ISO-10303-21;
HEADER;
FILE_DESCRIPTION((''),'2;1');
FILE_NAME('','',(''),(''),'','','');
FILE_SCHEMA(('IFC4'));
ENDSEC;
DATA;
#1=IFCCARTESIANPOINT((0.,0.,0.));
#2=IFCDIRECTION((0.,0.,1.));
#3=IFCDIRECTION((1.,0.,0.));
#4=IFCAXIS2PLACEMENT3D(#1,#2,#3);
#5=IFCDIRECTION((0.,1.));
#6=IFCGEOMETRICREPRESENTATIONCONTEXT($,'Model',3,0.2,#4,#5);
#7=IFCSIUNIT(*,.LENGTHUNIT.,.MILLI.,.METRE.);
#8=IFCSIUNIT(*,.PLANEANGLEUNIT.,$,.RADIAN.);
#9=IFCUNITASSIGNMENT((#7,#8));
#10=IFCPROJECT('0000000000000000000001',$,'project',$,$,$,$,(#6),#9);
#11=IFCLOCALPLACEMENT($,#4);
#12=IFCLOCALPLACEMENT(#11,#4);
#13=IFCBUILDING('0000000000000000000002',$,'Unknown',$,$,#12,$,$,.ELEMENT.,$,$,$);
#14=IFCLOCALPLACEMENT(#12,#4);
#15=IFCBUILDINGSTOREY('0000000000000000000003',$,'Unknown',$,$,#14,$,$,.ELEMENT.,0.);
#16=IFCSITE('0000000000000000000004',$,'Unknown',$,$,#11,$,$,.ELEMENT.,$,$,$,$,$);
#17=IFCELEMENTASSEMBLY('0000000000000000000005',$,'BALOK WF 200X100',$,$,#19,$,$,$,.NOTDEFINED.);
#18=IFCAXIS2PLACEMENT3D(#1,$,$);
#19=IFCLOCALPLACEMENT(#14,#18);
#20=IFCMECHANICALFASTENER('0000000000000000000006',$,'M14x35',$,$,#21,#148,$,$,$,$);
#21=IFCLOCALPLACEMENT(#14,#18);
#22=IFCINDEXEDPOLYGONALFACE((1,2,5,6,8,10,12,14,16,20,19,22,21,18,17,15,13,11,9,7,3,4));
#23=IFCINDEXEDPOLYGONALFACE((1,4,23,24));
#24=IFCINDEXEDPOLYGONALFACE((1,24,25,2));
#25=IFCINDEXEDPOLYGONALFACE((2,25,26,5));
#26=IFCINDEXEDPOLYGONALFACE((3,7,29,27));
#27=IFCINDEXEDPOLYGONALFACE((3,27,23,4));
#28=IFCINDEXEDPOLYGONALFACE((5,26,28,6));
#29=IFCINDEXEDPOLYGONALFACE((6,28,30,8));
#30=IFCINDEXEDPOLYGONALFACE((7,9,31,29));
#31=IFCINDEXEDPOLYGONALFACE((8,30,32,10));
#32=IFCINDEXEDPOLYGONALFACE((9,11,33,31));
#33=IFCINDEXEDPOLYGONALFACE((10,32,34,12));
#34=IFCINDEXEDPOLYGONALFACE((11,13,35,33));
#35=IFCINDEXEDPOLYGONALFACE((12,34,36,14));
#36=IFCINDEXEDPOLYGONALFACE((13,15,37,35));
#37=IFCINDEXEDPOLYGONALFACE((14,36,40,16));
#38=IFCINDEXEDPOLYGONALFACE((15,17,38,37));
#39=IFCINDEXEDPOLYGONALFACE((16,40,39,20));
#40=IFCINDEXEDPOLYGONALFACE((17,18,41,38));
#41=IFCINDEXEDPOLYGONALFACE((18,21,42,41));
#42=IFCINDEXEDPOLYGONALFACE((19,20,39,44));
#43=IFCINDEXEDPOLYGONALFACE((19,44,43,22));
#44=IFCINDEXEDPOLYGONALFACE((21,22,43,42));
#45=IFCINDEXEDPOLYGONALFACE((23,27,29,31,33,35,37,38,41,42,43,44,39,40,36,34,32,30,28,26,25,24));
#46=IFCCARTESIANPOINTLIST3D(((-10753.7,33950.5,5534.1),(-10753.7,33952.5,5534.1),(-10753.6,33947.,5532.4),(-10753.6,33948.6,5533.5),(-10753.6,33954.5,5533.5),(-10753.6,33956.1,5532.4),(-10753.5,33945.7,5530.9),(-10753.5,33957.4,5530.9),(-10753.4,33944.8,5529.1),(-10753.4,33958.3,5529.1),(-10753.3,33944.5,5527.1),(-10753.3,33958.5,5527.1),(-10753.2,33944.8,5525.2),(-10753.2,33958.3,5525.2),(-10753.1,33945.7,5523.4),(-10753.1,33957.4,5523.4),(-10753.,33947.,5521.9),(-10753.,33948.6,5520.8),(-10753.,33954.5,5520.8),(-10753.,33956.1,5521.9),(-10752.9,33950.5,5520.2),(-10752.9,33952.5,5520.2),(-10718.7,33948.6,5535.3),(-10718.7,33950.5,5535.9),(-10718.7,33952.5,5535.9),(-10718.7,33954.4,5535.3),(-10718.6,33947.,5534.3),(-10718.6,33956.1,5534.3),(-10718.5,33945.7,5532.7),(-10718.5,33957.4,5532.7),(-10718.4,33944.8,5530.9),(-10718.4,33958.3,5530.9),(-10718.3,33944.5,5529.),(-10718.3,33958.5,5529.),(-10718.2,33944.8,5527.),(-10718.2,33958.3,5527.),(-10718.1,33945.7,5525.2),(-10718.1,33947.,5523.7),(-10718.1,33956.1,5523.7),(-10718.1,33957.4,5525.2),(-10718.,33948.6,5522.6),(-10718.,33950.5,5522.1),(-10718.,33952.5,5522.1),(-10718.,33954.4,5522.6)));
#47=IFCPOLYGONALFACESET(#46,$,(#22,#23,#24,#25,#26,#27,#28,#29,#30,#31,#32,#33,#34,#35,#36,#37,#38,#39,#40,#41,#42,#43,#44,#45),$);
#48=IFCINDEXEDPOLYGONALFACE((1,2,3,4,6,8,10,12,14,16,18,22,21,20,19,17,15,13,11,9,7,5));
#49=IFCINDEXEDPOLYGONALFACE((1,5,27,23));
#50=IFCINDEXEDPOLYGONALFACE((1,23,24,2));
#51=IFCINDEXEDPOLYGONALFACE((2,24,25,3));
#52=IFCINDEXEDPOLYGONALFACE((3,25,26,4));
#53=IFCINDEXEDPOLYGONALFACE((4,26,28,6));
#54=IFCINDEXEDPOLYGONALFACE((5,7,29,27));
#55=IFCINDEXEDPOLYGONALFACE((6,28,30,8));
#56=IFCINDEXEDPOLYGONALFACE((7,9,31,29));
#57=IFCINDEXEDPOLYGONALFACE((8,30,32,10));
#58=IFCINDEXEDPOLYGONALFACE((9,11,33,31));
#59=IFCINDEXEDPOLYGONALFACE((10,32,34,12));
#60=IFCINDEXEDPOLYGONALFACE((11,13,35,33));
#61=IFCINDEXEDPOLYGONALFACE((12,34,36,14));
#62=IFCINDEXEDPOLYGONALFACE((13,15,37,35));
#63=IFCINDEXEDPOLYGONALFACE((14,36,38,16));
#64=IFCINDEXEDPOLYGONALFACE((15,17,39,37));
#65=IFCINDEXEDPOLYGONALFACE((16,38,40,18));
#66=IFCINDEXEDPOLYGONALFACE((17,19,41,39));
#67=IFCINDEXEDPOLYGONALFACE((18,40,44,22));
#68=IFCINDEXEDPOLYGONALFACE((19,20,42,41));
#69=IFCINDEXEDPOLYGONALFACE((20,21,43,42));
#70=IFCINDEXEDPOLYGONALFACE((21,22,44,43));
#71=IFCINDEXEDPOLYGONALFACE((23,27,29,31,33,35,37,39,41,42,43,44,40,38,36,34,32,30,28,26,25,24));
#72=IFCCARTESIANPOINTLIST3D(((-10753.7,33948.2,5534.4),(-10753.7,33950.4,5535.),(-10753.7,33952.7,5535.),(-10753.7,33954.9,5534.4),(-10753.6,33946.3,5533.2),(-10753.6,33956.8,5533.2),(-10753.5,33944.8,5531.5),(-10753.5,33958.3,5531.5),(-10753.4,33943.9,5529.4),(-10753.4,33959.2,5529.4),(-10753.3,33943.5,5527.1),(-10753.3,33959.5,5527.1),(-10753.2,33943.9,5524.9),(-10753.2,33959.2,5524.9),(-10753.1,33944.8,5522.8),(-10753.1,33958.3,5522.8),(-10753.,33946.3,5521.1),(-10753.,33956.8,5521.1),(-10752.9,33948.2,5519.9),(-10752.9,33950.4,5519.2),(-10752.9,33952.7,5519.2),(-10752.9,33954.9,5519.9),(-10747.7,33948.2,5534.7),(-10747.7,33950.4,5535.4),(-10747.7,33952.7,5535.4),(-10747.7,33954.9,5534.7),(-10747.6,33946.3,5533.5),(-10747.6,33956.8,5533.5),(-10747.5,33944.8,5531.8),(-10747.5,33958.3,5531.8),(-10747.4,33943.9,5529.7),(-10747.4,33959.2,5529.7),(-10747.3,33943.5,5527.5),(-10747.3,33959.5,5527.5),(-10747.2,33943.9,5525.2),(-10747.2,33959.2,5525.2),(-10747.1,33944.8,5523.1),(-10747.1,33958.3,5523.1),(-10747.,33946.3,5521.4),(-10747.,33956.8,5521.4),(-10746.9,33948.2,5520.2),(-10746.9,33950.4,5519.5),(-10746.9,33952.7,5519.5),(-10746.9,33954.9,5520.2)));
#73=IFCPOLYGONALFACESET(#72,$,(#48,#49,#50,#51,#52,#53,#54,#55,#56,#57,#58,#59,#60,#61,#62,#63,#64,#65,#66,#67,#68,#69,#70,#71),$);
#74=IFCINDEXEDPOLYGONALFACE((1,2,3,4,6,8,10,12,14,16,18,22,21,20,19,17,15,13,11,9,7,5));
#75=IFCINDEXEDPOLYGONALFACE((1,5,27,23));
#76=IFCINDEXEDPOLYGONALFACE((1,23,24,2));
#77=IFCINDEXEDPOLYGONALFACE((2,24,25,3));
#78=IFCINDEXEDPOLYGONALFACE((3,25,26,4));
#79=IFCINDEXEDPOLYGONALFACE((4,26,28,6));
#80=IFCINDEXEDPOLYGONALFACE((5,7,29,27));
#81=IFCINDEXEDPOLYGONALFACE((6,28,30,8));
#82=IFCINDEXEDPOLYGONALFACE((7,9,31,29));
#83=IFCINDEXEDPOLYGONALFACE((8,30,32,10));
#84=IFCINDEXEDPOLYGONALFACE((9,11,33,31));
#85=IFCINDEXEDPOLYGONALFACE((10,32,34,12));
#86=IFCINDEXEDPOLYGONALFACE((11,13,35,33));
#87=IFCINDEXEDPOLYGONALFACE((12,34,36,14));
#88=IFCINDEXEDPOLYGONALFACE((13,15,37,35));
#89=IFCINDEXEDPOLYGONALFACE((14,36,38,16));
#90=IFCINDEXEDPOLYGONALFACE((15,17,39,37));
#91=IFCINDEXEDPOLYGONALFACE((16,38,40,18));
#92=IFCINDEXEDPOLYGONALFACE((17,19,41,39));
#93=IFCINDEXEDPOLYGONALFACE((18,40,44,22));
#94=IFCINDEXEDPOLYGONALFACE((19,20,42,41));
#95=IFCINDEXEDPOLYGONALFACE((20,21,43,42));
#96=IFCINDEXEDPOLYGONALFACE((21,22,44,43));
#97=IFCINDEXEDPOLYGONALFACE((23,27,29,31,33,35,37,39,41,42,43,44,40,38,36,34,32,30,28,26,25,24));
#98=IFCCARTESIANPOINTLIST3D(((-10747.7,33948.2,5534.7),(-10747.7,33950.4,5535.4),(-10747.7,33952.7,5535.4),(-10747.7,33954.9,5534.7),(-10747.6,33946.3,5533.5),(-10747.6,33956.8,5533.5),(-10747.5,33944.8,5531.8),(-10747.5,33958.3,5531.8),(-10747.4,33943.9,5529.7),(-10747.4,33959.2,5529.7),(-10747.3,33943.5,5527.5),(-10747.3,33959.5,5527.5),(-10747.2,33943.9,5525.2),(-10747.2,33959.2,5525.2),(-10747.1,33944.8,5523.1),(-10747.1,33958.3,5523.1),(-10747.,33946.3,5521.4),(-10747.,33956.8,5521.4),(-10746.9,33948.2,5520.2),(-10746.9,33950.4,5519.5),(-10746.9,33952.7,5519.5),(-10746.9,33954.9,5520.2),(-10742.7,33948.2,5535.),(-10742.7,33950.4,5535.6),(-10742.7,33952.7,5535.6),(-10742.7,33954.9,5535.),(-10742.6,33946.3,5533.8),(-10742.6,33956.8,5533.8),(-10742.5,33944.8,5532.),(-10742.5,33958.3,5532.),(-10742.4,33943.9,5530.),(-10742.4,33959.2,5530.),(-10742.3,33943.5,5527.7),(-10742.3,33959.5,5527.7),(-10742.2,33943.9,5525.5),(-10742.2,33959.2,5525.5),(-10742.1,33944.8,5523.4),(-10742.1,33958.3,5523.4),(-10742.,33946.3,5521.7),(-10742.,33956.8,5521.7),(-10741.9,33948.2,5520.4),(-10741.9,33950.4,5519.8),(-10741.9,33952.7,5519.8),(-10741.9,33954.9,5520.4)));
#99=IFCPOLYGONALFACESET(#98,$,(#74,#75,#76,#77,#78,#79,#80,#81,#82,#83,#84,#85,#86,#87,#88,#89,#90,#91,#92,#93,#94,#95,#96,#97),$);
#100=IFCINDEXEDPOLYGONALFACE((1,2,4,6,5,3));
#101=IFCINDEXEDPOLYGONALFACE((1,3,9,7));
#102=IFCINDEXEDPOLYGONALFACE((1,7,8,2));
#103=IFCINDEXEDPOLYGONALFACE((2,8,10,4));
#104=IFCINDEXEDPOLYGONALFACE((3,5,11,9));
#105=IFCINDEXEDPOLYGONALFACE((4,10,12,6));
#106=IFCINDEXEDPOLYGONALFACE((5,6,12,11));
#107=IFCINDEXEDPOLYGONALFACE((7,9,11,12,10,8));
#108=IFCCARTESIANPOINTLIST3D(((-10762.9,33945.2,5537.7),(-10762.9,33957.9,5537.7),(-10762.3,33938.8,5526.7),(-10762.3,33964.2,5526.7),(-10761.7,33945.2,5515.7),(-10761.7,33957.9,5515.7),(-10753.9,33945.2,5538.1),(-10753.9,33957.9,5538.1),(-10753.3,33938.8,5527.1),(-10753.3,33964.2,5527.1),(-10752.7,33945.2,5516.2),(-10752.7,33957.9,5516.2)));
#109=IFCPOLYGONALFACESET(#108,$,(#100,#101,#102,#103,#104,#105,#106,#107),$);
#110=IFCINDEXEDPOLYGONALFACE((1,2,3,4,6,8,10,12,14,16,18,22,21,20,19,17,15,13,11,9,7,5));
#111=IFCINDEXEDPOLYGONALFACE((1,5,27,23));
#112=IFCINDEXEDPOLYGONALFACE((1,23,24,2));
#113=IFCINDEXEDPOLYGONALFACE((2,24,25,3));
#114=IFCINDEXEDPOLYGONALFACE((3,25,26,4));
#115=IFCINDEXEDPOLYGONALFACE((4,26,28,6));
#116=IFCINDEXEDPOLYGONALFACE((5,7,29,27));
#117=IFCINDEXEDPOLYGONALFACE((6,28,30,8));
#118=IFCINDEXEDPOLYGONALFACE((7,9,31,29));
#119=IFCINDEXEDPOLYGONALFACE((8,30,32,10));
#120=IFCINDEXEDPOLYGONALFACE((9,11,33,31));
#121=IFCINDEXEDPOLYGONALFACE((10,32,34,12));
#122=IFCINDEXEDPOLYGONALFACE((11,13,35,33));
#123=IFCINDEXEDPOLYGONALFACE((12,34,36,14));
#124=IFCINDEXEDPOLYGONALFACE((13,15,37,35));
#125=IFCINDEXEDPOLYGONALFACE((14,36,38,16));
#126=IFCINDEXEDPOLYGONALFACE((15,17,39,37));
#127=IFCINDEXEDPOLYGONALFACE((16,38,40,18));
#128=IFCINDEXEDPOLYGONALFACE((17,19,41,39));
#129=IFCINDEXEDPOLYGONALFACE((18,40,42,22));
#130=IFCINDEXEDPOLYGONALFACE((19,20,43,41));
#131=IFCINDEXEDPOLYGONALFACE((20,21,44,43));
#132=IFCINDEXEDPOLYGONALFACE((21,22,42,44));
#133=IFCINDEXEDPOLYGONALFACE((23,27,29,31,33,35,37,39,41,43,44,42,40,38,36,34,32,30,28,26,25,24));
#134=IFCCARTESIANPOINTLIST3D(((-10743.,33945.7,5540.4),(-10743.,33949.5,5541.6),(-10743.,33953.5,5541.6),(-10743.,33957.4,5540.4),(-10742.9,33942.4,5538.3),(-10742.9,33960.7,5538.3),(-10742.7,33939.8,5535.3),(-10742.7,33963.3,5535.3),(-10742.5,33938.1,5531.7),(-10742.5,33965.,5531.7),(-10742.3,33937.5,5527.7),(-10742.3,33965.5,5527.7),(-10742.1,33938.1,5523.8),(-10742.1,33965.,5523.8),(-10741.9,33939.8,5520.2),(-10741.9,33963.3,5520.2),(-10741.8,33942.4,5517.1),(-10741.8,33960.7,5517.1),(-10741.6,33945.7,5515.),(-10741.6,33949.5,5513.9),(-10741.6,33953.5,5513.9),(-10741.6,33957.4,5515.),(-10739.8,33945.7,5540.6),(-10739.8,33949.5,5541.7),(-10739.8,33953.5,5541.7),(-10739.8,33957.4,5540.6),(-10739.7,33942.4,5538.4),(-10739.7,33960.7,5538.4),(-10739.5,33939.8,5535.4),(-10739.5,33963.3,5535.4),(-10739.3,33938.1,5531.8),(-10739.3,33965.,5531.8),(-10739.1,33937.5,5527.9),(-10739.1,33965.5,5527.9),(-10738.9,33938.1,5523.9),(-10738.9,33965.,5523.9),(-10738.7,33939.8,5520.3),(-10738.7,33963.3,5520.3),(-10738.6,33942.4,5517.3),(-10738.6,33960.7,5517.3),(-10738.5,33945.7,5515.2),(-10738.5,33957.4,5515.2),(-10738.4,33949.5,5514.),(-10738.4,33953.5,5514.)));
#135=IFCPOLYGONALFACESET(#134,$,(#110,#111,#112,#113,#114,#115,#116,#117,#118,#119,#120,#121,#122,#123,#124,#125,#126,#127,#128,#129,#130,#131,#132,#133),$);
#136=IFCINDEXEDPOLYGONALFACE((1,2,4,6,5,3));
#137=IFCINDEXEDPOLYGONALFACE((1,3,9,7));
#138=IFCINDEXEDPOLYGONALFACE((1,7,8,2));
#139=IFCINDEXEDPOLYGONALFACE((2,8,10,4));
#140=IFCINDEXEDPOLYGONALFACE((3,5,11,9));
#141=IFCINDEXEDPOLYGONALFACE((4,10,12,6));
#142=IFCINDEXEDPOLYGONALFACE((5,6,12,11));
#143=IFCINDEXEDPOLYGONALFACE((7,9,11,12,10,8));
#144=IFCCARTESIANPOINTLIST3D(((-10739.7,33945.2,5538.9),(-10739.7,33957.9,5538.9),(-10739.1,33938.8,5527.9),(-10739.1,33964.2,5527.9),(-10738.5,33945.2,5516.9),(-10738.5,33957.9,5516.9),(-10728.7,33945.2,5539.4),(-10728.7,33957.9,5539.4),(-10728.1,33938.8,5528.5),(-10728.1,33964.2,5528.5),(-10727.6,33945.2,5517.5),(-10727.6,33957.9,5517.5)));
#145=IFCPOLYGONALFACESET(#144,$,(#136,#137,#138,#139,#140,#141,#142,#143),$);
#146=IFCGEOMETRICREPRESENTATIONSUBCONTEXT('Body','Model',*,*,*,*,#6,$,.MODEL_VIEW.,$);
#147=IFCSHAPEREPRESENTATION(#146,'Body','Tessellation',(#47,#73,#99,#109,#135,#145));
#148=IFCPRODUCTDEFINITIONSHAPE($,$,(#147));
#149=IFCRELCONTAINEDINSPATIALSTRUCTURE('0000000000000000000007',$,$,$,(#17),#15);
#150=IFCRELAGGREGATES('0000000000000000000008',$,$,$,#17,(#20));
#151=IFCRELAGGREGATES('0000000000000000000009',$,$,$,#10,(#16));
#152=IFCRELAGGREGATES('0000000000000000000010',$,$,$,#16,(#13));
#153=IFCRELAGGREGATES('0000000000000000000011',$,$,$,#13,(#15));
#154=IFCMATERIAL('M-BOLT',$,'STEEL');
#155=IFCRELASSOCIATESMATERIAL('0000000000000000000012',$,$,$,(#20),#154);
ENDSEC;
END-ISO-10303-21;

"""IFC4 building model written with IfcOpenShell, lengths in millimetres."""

from ifc_helpers import new_model, si_unit, direction, frame, origin_with_axes, place, context, subcontext, project, spatial, line, arc, indexed_curve, outline, extrude, source, transform, mapped, material, element, aggregate, save


model = new_model("IFC4")

# Units and contexts
model_context = context("Model", 3, precision=0.2, world=origin_with_axes(), true_north=direction((0.0, 1.0)))
body_context = subcontext(model_context, "Body", "Model", "MODEL_VIEW")
ifc_project = project(units=[si_unit("LENGTHUNIT", "METRE", prefix="MILLI"), si_unit("PLANEANGLEUNIT", "RADIAN")], contexts=[model_context])

# Site, building, storey
site_placement = place(None, origin_with_axes())
site = spatial("IfcSite", under=ifc_project, at=site_placement, Name="Unknown", CompositionType="ELEMENT")
building_placement = place(site_placement, origin_with_axes())
building = spatial("IfcBuilding", under=site, at=building_placement, Name="Unknown", CompositionType="ELEMENT")
storey_placement = place(building_placement, origin_with_axes())
storey = spatial("IfcBuildingStorey", under=building, at=storey_placement, Name="Unknown", CompositionType="ELEMENT", Elevation=0.0)

# Element assembly
assembly_1_placement = place(storey_placement, frame((-7044.1, 33866.5, 5721.5), z_axis=(0.0, 1.0, 0.0), x_axis=(-0.99863, 0.0, -0.052336)))
assembly_1 = element("IfcElementAssembly", 1, at=assembly_1_placement, inside=storey, Name="BALOK WF 200X100", PredefinedType="NOTDEFINED")

# Mechanical fastener
ifc_material_1 = material(Name="M-BOLT", Category="STEEL")
shared_shape_1 = source(origin_with_axes(), body_context, "Body", "SweptSolid", [
    extrude(outline(indexed_curve([(7.0, 0.0), (0.0, 7.0), (-7.0, 0.0), (0.0, -7.0)], segments=[arc(1, 2, 3), arc(3, 4, 1)])), frame((0.0, 0.0, -2.6), z_axis=(0.0, 0.0, -1.0), x_axis=(0.0, 1.0, 0.0)), (0.0, 0.0, 1.0), 35.0),
    extrude(outline(indexed_curve([(8.0, 0.0), (0.0, 8.0), (-8.0, 0.0), (0.0, -8.0)], segments=[arc(1, 2, 3), arc(3, 4, 1)])), frame((0.0, 0.0, -2.6), z_axis=(0.0, 0.0, -1.0), x_axis=(0.0, 1.0, 0.0)), (0.0, 0.0, 1.0), 6.0),
    extrude(outline(indexed_curve([(8.0, 0.0), (0.0, 8.0), (-8.0, 0.0), (0.0, -8.0)], segments=[arc(1, 2, 3), arc(3, 4, 1)])), frame((0.0, 0.0, -8.6), z_axis=(0.0, 0.0, -1.0), x_axis=(0.0, 1.0, 0.0)), (0.0, 0.0, 1.0), 5.0),
    extrude(outline(indexed_curve([(12.7, 0.0), (6.4, 11.0), (-6.4, 11.0), (-12.7, 0.0), (-6.4, -11.0), (6.4, -11.0)], segments=[line(1, 2, 3, 4, 5, 6, 1)])), frame((0.0, 0.0, 6.4), z_axis=(0.0, 0.0, -1.0), x_axis=(0.0, 1.0, 0.0)), (0.0, 0.0, 1.0), 9.0),
    extrude(outline(indexed_curve([(14.0, 0.0), (0.0, 14.0), (-14.0, 0.0), (0.0, -14.0)], segments=[arc(1, 2, 3), arc(3, 4, 1)])), frame((0.0, 0.0, -13.6), z_axis=(0.0, 0.0, -1.0), x_axis=(0.0, 1.0, 0.0)), (0.0, 0.0, 1.0), 3.2),
    extrude(outline(indexed_curve([(12.7, 0.0), (6.4, 11.0), (-6.4, 11.0), (-12.7, 0.0), (-6.4, -11.0), (6.4, -11.0)], segments=[line(1, 2, 3, 4, 5, 6, 1)])), frame((0.0, 0.0, -16.8), z_axis=(0.0, 0.0, -1.0), x_axis=(0.0, 1.0, 0.0)), (0.0, 0.0, 1.0), 11.0),
])
mechanical_fastener_1_placement = place(assembly_1_placement, frame((3716.9, 0.1, 85.0), z_axis=(1.0, 0.0, 0.000006), x_axis=(0.0, -1.0, 0.0)))
mechanical_fastener_1 = element("IfcMechanicalFastener", 2, at=mechanical_fastener_1_placement, material=ifc_material_1, Name="M14x35", context=body_context, shape_type="MappedRepresentation", body=[
    mapped(shared_shape_1, transform((0.0, 0.0, 0.0))),
])
aggregate(assembly_1, [mechanical_fastener_1])

save(model, "model.ifc")
